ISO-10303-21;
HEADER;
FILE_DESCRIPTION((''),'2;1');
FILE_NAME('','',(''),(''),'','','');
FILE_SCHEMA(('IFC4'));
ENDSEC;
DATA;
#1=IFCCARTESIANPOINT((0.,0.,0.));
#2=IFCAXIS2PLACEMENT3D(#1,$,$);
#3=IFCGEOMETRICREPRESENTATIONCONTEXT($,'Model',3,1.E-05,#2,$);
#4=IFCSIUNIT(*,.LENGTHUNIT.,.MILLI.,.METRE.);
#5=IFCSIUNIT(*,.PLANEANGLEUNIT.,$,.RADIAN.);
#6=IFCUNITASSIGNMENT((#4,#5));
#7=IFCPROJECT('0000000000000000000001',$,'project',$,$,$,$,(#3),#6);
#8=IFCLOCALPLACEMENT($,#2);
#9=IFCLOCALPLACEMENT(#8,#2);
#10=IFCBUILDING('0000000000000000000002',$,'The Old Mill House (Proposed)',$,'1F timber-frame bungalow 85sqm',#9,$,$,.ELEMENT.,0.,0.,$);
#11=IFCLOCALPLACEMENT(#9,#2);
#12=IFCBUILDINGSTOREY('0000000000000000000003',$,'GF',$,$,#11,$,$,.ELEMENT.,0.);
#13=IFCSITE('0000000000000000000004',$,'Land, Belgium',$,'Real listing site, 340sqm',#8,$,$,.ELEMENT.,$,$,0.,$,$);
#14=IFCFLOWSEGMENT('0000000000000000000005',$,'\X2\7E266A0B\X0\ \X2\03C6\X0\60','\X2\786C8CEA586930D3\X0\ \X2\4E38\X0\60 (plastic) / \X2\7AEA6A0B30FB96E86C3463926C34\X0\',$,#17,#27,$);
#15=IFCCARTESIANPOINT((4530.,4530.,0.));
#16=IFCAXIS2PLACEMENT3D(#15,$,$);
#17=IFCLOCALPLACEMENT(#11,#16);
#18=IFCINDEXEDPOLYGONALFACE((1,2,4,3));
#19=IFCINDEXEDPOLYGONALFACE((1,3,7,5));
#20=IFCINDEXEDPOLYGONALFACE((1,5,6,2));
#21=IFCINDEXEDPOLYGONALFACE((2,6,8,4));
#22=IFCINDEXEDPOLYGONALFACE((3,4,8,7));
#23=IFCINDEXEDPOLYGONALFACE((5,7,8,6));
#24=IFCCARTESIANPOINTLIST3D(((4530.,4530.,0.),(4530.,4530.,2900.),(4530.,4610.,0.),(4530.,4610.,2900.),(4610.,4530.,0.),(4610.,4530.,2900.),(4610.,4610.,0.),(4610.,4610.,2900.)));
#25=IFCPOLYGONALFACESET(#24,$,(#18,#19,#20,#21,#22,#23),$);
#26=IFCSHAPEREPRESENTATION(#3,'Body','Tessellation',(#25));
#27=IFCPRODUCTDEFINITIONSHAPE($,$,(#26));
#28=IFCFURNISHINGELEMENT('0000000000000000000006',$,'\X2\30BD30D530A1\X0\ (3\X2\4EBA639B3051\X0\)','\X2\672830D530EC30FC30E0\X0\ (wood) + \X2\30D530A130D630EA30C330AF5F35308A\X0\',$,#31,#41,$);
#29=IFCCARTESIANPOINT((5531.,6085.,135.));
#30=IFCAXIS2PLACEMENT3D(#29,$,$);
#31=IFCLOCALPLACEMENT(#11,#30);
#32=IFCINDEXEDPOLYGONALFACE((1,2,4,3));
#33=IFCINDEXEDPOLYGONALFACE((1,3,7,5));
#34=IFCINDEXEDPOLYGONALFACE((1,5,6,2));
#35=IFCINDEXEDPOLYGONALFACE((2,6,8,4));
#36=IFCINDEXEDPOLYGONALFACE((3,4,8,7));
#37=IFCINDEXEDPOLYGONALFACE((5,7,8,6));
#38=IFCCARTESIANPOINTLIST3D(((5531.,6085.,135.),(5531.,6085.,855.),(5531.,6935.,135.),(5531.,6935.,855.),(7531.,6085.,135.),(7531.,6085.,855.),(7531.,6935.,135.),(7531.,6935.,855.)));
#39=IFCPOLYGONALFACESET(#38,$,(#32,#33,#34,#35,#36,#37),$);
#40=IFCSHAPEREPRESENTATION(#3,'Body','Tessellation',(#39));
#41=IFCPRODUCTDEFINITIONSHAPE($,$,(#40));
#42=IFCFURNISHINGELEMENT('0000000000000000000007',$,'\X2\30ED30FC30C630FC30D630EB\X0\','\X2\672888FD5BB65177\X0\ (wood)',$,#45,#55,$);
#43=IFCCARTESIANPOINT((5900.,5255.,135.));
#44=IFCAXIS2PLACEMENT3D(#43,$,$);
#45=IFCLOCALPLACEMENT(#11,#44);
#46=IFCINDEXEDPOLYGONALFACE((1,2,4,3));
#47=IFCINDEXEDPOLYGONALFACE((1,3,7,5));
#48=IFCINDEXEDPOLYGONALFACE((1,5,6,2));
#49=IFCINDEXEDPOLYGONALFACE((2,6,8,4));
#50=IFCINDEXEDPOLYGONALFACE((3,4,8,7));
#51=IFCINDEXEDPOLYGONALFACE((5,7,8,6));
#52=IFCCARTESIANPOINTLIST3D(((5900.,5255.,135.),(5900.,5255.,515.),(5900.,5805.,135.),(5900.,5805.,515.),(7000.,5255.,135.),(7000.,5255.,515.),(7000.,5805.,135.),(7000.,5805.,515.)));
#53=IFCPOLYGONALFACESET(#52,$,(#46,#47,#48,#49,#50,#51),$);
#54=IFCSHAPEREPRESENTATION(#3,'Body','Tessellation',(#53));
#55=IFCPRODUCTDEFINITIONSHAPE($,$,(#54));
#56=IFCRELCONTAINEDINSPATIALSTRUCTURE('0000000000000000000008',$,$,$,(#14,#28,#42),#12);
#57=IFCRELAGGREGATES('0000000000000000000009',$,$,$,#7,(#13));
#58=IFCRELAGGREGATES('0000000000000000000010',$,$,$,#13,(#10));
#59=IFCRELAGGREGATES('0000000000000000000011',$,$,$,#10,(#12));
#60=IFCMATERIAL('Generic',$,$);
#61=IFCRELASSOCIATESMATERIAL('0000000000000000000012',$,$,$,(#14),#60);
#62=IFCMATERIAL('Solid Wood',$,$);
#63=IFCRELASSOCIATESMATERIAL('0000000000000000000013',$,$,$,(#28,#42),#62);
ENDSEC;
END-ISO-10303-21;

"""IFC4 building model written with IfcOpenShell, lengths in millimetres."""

from ifc_helpers import new_model, si_unit, frame, frame_2d, origin, place, context, project, spatial, rectangle, extrude, material, element, save


model = new_model("IFC4")

# Units and contexts
model_context = context("Model", 3, precision=1e-05, world=origin())
ifc_project = project(units=[si_unit("LENGTHUNIT", "METRE", prefix="MILLI"), si_unit("PLANEANGLEUNIT", "RADIAN")], contexts=[model_context])

# Site, building, storey
site_placement = place(None, origin())
site = spatial("IfcSite", under=ifc_project, at=site_placement, Name="Land, Belgium", ObjectType="Real listing site, 340sqm", CompositionType="ELEMENT", RefElevation=0.0)
building_placement = place(site_placement, origin())
building = spatial("IfcBuilding", under=site, at=building_placement, Name="The Old Mill House (Proposed)", ObjectType="1F timber-frame bungalow 85sqm", CompositionType="ELEMENT", ElevationOfRefHeight=0.0, ElevationOfTerrain=0.0)
storey_placement = place(building_placement, origin())
storey = spatial("IfcBuildingStorey", under=building, at=storey_placement, Name="GF", CompositionType="ELEMENT", Elevation=0.0)

# Shared definitions
ifc_material_1 = material(Name="Solid Wood")

# Shared definitions
ifc_material_2 = material(Name="Generic")

# Flow segment
flow_segment_1_placement = place(storey_placement, frame((4530.0, 4530.0, 0.0)))
element("IfcFlowSegment", 1, at=flow_segment_1_placement, inside=storey, material=ifc_material_2, Name="縦樋 φ60", Description="硬質塩ビ 丸60 (plastic) / 竪樋・雨水排水", context=model_context, shape_type="SweptSolid", body=[
    extrude(rectangle(XDim=80.0, YDim=80.0, at=frame_2d((40.0, 40.0))), frame((4530.0, 4530.0, 0.0)), (0.0, 0.0, 1.0), 2900.0),
])

# Furnishing elements
furnishing_1_placement = place(storey_placement, frame((5531.0, 6085.0, 135.0)))
element("IfcFurnishingElement", 2, at=furnishing_1_placement, inside=storey, material=ifc_material_1, Name="ソファ (3人掛け)", Description="木フレーム (wood) + ファブリック張り", context=model_context, shape_type="SweptSolid", body=[
    extrude(rectangle(XDim=2000.0, YDim=850.0, at=frame_2d((1000.0, 425.0))), frame((5531.0, 6085.0, 135.0)), (0.0, 0.0, 1.0), 720.0),
])
furnishing_2_placement = place(storey_placement, frame((5900.0, 5255.0, 135.0)))
element("IfcFurnishingElement", 3, at=furnishing_2_placement, inside=storey, material=ifc_material_1, Name="ローテーブル", Description="木製家具 (wood)", context=model_context, shape_type="SweptSolid", body=[
    extrude(rectangle(XDim=1100.0, YDim=550.0, at=frame_2d((550.0, 275.0))), frame((5900.0, 5255.0, 135.0)), (0.0, 0.0, 1.0), 380.0),
])

save(model, "model.ifc")
